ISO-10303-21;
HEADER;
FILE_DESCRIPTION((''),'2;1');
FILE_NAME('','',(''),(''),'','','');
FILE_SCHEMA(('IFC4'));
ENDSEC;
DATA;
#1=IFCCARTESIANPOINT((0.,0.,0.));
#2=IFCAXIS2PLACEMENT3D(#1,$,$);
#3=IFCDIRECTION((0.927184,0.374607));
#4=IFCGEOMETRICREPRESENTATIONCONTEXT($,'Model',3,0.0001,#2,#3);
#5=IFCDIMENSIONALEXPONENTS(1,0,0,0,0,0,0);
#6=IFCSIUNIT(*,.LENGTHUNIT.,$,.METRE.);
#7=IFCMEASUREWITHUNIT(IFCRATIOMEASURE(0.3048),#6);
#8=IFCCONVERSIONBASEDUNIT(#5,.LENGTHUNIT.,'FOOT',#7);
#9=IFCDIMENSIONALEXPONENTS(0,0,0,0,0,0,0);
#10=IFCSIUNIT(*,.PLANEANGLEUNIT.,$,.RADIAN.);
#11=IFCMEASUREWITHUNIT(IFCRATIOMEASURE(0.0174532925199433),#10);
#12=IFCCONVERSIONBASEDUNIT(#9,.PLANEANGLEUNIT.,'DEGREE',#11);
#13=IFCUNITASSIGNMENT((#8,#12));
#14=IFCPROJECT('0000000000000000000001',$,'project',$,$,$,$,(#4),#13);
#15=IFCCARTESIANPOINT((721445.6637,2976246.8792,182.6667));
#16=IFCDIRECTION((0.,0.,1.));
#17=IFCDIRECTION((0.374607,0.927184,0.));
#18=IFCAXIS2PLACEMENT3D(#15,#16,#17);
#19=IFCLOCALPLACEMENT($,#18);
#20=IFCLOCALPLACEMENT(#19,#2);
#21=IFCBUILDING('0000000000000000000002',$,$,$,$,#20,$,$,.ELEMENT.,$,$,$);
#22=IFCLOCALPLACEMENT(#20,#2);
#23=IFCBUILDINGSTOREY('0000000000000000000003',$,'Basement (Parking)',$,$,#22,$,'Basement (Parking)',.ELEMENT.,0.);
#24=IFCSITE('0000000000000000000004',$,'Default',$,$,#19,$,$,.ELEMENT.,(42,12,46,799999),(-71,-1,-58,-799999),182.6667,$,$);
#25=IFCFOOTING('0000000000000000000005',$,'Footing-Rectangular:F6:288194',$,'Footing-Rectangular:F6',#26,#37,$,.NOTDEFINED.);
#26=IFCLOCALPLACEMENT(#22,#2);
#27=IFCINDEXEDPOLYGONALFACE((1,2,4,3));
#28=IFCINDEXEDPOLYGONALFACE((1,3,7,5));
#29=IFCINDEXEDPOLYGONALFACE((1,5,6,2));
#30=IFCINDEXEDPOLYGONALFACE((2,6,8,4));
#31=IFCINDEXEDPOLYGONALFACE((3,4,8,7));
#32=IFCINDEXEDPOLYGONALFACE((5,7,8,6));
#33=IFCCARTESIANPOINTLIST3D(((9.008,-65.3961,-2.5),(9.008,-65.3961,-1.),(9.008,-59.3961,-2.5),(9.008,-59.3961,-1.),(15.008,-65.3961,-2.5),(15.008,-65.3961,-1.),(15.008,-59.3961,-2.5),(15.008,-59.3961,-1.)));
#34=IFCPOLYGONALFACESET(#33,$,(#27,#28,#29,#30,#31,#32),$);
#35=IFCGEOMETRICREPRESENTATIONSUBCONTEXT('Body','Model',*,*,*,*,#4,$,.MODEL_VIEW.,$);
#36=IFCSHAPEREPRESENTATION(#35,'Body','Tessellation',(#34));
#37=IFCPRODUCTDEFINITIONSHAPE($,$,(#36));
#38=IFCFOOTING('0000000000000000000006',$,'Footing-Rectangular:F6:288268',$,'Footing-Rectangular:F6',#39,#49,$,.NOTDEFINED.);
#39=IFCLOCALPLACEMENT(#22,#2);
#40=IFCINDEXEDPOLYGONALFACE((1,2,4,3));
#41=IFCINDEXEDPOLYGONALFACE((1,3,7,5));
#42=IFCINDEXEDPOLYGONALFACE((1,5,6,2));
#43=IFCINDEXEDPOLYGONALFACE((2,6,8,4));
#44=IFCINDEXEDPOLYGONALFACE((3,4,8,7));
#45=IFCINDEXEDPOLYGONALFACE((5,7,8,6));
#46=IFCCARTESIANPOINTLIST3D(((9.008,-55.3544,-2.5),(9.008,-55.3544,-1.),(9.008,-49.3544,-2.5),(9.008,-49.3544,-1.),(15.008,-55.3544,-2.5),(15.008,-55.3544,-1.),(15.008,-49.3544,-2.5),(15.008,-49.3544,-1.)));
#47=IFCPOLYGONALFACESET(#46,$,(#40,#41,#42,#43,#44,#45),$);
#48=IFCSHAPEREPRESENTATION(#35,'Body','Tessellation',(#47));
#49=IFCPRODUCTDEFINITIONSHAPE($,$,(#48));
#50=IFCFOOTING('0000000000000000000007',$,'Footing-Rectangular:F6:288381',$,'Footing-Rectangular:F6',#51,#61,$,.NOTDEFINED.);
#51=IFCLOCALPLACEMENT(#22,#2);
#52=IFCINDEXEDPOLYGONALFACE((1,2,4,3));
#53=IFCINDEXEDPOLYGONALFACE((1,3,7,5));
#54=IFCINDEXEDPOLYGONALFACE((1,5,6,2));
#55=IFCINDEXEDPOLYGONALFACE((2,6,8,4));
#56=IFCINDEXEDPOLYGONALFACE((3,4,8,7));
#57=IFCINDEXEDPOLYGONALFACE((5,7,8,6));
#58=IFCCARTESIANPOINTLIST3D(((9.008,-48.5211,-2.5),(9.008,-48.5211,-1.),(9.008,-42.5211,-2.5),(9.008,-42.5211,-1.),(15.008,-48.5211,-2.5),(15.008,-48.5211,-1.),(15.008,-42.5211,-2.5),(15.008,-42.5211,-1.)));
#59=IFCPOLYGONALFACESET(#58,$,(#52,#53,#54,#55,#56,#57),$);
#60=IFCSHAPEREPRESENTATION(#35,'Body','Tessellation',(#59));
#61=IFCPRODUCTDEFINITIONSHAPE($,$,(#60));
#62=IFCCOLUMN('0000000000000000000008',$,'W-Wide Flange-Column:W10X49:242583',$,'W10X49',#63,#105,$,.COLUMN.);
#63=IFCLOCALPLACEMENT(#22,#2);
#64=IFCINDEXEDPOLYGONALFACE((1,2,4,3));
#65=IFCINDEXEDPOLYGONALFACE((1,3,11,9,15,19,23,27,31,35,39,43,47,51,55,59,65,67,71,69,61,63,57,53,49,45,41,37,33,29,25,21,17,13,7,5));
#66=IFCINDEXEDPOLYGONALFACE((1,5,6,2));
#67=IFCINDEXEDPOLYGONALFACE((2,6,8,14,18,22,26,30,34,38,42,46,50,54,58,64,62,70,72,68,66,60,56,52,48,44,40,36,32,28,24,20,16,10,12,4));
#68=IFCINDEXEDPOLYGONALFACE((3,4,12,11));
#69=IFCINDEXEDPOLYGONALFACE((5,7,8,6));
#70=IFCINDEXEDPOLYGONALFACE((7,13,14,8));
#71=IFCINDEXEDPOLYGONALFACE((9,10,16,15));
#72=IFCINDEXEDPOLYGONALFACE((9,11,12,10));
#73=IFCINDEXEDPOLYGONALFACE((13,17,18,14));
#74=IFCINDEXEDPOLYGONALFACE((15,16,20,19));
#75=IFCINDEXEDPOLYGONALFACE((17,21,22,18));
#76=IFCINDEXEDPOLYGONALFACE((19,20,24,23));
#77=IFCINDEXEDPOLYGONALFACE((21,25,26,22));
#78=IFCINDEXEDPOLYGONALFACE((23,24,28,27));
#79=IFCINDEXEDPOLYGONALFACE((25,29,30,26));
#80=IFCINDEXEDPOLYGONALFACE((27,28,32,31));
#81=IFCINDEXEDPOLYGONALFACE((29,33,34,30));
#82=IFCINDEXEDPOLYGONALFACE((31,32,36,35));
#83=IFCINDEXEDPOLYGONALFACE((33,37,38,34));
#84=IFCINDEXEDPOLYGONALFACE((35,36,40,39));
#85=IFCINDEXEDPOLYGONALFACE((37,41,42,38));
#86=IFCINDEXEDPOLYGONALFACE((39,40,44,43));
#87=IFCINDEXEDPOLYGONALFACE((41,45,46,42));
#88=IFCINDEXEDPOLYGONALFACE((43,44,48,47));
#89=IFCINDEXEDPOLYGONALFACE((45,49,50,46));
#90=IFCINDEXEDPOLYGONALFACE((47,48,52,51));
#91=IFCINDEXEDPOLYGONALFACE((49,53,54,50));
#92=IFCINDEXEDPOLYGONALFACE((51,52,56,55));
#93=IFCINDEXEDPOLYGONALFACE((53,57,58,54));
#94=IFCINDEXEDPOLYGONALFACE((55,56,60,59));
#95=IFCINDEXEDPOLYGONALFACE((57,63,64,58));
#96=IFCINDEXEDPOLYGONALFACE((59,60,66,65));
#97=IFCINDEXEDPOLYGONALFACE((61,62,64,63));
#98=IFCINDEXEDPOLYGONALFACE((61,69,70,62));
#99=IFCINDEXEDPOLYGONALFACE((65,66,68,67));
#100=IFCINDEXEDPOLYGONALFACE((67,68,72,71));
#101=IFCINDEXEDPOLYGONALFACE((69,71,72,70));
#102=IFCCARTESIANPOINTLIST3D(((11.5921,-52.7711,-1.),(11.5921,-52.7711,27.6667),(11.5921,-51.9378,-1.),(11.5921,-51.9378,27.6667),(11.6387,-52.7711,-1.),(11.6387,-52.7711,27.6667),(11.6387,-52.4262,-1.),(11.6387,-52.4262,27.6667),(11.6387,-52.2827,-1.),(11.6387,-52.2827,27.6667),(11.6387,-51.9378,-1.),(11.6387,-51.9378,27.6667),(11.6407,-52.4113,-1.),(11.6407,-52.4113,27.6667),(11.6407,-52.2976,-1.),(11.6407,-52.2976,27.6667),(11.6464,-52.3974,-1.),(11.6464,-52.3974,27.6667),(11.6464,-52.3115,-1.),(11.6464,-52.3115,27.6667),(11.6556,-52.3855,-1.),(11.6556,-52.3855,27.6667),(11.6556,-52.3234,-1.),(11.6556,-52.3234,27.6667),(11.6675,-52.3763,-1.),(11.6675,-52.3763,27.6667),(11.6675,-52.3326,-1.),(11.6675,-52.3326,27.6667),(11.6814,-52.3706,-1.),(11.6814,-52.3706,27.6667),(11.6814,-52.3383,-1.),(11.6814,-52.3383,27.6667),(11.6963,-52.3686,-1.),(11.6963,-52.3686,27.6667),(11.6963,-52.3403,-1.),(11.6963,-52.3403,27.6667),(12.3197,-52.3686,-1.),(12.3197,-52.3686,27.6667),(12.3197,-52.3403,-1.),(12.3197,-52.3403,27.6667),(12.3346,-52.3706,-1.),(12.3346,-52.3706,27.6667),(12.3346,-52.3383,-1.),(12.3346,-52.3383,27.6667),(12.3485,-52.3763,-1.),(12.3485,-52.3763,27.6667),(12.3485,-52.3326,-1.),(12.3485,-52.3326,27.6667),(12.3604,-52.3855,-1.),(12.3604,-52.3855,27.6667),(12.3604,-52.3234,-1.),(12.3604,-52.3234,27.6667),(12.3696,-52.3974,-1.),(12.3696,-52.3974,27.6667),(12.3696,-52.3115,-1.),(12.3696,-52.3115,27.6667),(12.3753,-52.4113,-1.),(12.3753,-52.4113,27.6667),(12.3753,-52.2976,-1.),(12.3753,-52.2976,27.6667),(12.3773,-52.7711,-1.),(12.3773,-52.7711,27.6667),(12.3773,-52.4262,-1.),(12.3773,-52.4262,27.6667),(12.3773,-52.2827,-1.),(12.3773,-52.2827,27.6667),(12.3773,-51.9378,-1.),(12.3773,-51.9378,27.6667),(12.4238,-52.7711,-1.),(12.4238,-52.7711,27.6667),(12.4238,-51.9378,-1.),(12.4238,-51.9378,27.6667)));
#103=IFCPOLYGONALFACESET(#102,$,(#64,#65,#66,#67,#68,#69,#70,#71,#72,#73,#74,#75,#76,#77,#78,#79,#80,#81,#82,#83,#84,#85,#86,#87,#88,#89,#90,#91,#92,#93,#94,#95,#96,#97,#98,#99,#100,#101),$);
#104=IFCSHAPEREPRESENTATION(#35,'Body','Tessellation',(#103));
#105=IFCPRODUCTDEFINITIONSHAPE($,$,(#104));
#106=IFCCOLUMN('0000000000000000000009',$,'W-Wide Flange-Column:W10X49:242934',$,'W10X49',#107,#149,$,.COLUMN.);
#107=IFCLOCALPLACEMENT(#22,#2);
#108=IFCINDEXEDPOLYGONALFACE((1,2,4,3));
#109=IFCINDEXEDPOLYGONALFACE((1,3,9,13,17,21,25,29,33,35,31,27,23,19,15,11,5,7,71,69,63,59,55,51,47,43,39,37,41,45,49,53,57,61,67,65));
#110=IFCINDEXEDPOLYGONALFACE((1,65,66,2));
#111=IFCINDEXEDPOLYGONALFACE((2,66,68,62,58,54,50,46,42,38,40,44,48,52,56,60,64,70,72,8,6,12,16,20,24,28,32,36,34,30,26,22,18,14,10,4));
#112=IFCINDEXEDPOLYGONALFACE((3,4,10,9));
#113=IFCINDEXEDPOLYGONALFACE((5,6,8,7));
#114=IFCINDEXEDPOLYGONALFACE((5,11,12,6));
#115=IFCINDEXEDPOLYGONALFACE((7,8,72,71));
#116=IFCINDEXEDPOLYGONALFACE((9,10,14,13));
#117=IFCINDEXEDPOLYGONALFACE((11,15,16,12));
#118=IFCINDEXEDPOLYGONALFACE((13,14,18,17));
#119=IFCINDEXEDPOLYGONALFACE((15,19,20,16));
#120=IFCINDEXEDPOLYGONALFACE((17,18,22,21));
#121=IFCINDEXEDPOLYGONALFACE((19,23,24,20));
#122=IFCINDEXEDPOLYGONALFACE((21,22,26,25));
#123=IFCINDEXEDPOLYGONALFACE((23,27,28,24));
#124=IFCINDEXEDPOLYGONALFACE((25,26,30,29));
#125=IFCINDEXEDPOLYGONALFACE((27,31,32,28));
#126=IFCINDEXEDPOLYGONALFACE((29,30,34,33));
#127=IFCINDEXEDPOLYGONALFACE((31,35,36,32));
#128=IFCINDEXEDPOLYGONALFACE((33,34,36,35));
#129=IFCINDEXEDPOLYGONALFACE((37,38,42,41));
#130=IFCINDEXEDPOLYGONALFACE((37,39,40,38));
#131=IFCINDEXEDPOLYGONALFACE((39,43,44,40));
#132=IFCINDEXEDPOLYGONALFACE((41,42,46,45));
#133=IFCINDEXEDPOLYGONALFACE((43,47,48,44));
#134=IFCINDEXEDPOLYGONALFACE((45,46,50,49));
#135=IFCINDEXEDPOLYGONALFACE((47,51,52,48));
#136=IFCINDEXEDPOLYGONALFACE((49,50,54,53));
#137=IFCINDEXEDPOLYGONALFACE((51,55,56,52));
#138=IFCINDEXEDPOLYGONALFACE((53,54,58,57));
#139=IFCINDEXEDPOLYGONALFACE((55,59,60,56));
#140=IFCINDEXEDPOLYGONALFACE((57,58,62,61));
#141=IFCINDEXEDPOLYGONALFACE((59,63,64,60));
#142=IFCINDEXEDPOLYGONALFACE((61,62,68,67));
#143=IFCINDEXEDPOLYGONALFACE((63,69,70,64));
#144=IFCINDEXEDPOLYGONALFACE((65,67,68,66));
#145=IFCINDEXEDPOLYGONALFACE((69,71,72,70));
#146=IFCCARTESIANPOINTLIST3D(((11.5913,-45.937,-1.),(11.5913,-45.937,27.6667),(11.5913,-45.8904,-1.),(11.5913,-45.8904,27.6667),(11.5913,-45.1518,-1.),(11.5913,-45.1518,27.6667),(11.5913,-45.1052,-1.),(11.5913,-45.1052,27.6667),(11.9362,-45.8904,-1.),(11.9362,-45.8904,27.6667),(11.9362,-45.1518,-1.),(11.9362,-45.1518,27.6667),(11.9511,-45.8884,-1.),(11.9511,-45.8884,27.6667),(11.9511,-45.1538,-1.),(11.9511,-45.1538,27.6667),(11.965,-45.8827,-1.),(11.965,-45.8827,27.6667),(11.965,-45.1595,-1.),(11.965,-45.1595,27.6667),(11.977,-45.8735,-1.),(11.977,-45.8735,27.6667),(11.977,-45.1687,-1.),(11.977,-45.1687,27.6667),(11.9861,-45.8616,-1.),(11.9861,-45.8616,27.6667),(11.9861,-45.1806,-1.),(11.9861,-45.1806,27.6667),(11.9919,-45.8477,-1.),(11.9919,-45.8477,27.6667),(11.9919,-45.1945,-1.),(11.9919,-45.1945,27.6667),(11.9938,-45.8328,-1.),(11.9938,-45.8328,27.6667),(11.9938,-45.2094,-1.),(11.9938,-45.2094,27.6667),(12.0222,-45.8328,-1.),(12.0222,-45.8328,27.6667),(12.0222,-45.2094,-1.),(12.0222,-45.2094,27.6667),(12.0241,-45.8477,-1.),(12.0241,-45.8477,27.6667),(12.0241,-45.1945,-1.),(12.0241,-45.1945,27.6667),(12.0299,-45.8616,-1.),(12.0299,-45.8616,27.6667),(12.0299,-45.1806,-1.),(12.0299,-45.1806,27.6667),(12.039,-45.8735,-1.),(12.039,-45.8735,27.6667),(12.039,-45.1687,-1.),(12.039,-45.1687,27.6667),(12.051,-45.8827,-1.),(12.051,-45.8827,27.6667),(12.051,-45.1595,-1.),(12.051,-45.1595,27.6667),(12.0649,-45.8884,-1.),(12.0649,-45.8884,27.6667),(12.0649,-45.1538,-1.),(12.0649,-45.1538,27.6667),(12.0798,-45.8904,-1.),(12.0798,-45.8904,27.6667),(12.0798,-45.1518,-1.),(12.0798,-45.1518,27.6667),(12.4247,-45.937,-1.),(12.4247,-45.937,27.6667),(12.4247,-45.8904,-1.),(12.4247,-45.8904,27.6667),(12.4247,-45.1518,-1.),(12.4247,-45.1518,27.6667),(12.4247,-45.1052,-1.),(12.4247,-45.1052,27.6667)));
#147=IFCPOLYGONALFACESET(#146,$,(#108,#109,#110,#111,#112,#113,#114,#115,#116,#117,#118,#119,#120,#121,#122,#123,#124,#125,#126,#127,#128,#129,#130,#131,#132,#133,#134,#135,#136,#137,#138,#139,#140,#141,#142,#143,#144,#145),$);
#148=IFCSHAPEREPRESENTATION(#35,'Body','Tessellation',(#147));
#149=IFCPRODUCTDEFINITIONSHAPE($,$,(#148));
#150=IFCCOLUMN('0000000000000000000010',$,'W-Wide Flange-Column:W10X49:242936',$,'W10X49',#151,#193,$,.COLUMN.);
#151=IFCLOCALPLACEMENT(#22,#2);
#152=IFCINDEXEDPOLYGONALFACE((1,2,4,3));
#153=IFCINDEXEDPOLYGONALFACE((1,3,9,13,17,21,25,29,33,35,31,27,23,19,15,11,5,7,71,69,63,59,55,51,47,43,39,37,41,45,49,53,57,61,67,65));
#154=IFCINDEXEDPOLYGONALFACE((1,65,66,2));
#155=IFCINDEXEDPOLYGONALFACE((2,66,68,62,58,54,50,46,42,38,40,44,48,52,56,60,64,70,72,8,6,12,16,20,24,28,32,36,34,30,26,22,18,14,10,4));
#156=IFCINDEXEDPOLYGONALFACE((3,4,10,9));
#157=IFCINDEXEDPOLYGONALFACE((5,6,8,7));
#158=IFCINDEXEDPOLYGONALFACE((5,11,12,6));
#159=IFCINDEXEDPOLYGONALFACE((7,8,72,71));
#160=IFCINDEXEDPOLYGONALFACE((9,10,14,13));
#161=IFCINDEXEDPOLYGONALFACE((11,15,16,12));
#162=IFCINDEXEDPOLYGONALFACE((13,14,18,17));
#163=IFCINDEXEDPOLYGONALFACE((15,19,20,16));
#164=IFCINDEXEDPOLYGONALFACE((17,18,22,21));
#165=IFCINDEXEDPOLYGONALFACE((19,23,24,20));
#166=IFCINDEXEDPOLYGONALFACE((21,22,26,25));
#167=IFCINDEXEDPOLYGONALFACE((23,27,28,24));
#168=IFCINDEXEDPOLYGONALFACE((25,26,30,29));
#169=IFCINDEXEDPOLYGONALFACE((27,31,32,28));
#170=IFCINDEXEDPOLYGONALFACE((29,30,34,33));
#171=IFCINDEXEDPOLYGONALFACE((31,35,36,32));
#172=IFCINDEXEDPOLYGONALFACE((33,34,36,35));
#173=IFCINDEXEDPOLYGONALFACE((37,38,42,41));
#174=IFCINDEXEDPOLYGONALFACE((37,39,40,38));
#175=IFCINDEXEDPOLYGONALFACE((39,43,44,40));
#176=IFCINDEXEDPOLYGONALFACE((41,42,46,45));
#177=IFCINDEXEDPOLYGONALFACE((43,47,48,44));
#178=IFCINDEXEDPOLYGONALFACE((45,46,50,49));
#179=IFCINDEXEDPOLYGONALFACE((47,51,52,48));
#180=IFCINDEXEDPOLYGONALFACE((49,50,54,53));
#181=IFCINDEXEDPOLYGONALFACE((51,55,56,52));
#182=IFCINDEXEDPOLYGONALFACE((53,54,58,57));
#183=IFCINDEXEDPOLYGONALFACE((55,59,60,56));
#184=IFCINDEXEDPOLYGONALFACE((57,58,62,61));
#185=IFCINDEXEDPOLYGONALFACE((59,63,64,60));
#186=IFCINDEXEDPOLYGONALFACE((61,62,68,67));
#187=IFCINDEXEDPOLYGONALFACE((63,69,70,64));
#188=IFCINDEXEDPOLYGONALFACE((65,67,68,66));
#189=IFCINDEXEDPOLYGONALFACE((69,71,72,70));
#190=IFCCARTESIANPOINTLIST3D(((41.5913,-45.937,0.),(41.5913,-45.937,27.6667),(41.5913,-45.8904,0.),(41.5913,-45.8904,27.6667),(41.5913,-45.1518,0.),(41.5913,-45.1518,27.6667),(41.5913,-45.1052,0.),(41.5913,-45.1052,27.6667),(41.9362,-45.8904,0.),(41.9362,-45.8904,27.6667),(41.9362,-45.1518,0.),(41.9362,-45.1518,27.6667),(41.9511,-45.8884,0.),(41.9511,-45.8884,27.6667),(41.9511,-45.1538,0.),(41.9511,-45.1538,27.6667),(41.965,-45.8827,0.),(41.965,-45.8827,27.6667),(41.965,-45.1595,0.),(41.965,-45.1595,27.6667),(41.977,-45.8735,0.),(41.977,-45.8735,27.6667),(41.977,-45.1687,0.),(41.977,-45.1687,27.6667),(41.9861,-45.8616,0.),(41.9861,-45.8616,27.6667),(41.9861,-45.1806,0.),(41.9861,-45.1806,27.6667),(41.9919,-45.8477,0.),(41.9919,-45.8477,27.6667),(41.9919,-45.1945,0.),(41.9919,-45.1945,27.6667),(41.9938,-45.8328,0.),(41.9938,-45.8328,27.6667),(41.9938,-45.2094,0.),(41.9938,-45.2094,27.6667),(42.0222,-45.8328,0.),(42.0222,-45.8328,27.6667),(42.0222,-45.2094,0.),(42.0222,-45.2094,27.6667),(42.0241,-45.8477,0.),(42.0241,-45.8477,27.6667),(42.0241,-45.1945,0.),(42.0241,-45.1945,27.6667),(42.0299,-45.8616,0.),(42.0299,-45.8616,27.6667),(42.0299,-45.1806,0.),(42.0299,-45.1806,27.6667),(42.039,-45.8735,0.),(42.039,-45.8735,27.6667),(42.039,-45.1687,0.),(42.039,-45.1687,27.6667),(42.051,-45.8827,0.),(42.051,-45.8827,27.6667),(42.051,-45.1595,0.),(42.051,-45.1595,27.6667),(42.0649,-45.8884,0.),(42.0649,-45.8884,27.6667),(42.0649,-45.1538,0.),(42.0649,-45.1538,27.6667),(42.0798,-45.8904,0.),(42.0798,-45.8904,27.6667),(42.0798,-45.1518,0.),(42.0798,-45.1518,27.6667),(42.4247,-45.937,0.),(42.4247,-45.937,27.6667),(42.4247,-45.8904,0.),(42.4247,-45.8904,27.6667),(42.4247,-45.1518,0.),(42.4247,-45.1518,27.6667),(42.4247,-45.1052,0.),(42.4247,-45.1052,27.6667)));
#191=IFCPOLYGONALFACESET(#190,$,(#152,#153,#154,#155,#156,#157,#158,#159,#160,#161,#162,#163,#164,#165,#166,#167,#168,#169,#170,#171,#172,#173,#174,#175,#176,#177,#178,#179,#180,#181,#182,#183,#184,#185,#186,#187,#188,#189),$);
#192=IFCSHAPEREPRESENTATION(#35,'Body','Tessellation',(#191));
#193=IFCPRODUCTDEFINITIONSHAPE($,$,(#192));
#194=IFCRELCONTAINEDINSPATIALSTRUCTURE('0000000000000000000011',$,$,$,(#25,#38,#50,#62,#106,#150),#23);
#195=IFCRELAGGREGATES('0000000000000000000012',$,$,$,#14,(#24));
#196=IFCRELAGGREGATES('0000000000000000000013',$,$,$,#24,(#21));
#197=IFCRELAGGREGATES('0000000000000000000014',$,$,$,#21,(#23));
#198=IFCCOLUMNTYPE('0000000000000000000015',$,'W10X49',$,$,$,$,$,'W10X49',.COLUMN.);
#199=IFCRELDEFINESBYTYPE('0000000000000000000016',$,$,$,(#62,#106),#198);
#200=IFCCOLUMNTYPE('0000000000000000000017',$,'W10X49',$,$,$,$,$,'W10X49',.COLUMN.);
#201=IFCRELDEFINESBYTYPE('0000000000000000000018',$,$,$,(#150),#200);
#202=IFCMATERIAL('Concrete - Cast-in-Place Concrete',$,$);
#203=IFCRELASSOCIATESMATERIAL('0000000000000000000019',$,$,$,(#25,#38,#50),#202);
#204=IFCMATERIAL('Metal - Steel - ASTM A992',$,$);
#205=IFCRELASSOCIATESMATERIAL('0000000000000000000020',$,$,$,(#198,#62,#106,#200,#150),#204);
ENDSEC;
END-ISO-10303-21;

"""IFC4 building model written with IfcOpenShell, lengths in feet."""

from ifc_helpers import new_model, entity, si_unit, converted_unit, direction, frame, frame_2d, origin, origin_2d_with_axis, place, context, subcontext, project, spatial, rectangle, i_section, extrude, source, transform, mapped, material, type_object, type_shapes, element, save


model = new_model("IFC4")

# Units and contexts
model_context = context("Model", 3, precision=0.0001, world=origin(), true_north=direction((0.927184, 0.374607)))
body_context = subcontext(model_context, "Body", "Model", "MODEL_VIEW")
ifc_project = project(units=[converted_unit("LENGTHUNIT", "FOOT", entity("IfcRatioMeasure", 0.3048), si_unit("LENGTHUNIT", "METRE"), dimensions=[1, 0, 0, 0, 0, 0, 0]), converted_unit("PLANEANGLEUNIT", "DEGREE", entity("IfcRatioMeasure", 0.0174532925199433), si_unit("PLANEANGLEUNIT", "RADIAN"), dimensions=[0, 0, 0, 0, 0, 0, 0])], contexts=[model_context])

# Site, building, storey
site_placement = place(None, frame((721445.6637, 2976246.8792, 182.6667), z_axis=(0.0, 0.0, 1.0), x_axis=(0.374607, 0.927184, 0.0)))
site = spatial("IfcSite", under=ifc_project, at=site_placement, Name="Default", CompositionType="ELEMENT", RefLatitude=(42, 12, 46, 799999), RefLongitude=(-71, -1, -58, -799999), RefElevation=182.6667)
building_placement = place(site_placement, origin())
building = spatial("IfcBuilding", under=site, at=building_placement, CompositionType="ELEMENT")
storey_placement = place(building_placement, origin())
storey = spatial("IfcBuildingStorey", under=building, at=storey_placement, Name="Basement (Parking)", LongName="Basement (Parking)", CompositionType="ELEMENT", Elevation=0.0)

# Footings
ifc_material_1 = material(Name="Concrete - Cast-in-Place Concrete")
for number, where, name in (
    (1, (9.008, -65.3961, -2.5), "Footing-Rectangular:F6:288194"),
    (2, (9.008, -55.3544, -2.5), "Footing-Rectangular:F6:288268"),
    (3, (9.008, -48.5211, -2.5), "Footing-Rectangular:F6:288381"),
):
    element("IfcFooting", number, at=place(storey_placement, frame(where)), inside=storey, material=ifc_material_1, Name=name, ObjectType="Footing-Rectangular:F6", PredefinedType="NOTDEFINED", context=body_context, shape_type="SweptSolid", body=[
        extrude(rectangle(XDim=6.0, YDim=6.0, at=origin_2d_with_axis()), frame((3.0, 3.0, 0.0), z_axis=(0.0, 0.0, 1.0), x_axis=(-1.0, 0.0, 0.0)), (0.0, 0.0, 1.0), 1.5),
    ])

# Columns
ifc_material_2 = material(Name="Metal - Steel - ASTM A992")
column_type_1 = type_object("IfcColumnType", Name="W10X49", ElementType="W10X49", PredefinedType="COLUMN", material=ifc_material_2)
shared_shape_1 = source(origin(), body_context, "Body", "SweptSolid", [
    extrude(i_section(OverallWidth=0.8333, OverallDepth=0.8317, WebThickness=0.0283, FlangeThickness=0.0465, FilletRadius=0.0576, at=frame_2d((0.0, 0.0), x_axis=(0.0, 1.0))), frame((0.0, 0.0, -1.0), z_axis=(0.0, 0.0, 1.0), x_axis=(0.0, -1.0, 0.0)), (0.0, 0.0, 1.0), 28.6667),
])
type_shapes(column_type_1, [shared_shape_1])
for number, where, z_axis, x_axis, name in (
    (4, (12.008, -52.3544, 0.0), (0.0, 0.0, 1.0), (0.0, 1.0, 0.0), "W-Wide Flange-Column:W10X49:242583"),
    (5, (12.008, -45.5211, 0.0), (0.0, 0.0, 1.0), (-1.0, 0.0, 0.0), "W-Wide Flange-Column:W10X49:242934"),
):
    element("IfcColumn", number, at=place(storey_placement, frame(where, z_axis=z_axis, x_axis=x_axis)), inside=storey, type_object=column_type_1, material=ifc_material_2, Name=name, ObjectType="W10X49", PredefinedType="COLUMN", context=body_context, shape_type="MappedRepresentation", body=[
        mapped(shared_shape_1, transform((0.0, 0.0, 0.0), scale=1.0)),
    ])
column_type_2 = type_object("IfcColumnType", Name="W10X49", ElementType="W10X49", PredefinedType="COLUMN", material=ifc_material_2)
shared_shape_2 = source(origin(), body_context, "Body", "SweptSolid", [
    extrude(i_section(OverallWidth=0.8333, OverallDepth=0.8317, WebThickness=0.0283, FlangeThickness=0.0465, FilletRadius=0.0576, at=frame_2d((0.0, 0.0), x_axis=(0.0, 1.0))), frame((0.0, 0.0, 0.0), z_axis=(0.0, 0.0, 1.0), x_axis=(0.0, -1.0, 0.0)), (0.0, 0.0, 1.0), 27.6667),
])
type_shapes(column_type_2, [shared_shape_2])
column_placement = place(storey_placement, frame((42.008, -45.5211, 0.0), z_axis=(0.0, 0.0, 1.0), x_axis=(-1.0, 0.0, 0.0)))
element("IfcColumn", 6, at=column_placement, inside=storey, type_object=column_type_2, material=ifc_material_2, Name="W-Wide Flange-Column:W10X49:242936", ObjectType="W10X49", PredefinedType="COLUMN", context=body_context, shape_type="MappedRepresentation", body=[
    mapped(shared_shape_2, transform((0.0, 0.0, 0.0), scale=1.0)),
])

save(model, "model.ifc")
